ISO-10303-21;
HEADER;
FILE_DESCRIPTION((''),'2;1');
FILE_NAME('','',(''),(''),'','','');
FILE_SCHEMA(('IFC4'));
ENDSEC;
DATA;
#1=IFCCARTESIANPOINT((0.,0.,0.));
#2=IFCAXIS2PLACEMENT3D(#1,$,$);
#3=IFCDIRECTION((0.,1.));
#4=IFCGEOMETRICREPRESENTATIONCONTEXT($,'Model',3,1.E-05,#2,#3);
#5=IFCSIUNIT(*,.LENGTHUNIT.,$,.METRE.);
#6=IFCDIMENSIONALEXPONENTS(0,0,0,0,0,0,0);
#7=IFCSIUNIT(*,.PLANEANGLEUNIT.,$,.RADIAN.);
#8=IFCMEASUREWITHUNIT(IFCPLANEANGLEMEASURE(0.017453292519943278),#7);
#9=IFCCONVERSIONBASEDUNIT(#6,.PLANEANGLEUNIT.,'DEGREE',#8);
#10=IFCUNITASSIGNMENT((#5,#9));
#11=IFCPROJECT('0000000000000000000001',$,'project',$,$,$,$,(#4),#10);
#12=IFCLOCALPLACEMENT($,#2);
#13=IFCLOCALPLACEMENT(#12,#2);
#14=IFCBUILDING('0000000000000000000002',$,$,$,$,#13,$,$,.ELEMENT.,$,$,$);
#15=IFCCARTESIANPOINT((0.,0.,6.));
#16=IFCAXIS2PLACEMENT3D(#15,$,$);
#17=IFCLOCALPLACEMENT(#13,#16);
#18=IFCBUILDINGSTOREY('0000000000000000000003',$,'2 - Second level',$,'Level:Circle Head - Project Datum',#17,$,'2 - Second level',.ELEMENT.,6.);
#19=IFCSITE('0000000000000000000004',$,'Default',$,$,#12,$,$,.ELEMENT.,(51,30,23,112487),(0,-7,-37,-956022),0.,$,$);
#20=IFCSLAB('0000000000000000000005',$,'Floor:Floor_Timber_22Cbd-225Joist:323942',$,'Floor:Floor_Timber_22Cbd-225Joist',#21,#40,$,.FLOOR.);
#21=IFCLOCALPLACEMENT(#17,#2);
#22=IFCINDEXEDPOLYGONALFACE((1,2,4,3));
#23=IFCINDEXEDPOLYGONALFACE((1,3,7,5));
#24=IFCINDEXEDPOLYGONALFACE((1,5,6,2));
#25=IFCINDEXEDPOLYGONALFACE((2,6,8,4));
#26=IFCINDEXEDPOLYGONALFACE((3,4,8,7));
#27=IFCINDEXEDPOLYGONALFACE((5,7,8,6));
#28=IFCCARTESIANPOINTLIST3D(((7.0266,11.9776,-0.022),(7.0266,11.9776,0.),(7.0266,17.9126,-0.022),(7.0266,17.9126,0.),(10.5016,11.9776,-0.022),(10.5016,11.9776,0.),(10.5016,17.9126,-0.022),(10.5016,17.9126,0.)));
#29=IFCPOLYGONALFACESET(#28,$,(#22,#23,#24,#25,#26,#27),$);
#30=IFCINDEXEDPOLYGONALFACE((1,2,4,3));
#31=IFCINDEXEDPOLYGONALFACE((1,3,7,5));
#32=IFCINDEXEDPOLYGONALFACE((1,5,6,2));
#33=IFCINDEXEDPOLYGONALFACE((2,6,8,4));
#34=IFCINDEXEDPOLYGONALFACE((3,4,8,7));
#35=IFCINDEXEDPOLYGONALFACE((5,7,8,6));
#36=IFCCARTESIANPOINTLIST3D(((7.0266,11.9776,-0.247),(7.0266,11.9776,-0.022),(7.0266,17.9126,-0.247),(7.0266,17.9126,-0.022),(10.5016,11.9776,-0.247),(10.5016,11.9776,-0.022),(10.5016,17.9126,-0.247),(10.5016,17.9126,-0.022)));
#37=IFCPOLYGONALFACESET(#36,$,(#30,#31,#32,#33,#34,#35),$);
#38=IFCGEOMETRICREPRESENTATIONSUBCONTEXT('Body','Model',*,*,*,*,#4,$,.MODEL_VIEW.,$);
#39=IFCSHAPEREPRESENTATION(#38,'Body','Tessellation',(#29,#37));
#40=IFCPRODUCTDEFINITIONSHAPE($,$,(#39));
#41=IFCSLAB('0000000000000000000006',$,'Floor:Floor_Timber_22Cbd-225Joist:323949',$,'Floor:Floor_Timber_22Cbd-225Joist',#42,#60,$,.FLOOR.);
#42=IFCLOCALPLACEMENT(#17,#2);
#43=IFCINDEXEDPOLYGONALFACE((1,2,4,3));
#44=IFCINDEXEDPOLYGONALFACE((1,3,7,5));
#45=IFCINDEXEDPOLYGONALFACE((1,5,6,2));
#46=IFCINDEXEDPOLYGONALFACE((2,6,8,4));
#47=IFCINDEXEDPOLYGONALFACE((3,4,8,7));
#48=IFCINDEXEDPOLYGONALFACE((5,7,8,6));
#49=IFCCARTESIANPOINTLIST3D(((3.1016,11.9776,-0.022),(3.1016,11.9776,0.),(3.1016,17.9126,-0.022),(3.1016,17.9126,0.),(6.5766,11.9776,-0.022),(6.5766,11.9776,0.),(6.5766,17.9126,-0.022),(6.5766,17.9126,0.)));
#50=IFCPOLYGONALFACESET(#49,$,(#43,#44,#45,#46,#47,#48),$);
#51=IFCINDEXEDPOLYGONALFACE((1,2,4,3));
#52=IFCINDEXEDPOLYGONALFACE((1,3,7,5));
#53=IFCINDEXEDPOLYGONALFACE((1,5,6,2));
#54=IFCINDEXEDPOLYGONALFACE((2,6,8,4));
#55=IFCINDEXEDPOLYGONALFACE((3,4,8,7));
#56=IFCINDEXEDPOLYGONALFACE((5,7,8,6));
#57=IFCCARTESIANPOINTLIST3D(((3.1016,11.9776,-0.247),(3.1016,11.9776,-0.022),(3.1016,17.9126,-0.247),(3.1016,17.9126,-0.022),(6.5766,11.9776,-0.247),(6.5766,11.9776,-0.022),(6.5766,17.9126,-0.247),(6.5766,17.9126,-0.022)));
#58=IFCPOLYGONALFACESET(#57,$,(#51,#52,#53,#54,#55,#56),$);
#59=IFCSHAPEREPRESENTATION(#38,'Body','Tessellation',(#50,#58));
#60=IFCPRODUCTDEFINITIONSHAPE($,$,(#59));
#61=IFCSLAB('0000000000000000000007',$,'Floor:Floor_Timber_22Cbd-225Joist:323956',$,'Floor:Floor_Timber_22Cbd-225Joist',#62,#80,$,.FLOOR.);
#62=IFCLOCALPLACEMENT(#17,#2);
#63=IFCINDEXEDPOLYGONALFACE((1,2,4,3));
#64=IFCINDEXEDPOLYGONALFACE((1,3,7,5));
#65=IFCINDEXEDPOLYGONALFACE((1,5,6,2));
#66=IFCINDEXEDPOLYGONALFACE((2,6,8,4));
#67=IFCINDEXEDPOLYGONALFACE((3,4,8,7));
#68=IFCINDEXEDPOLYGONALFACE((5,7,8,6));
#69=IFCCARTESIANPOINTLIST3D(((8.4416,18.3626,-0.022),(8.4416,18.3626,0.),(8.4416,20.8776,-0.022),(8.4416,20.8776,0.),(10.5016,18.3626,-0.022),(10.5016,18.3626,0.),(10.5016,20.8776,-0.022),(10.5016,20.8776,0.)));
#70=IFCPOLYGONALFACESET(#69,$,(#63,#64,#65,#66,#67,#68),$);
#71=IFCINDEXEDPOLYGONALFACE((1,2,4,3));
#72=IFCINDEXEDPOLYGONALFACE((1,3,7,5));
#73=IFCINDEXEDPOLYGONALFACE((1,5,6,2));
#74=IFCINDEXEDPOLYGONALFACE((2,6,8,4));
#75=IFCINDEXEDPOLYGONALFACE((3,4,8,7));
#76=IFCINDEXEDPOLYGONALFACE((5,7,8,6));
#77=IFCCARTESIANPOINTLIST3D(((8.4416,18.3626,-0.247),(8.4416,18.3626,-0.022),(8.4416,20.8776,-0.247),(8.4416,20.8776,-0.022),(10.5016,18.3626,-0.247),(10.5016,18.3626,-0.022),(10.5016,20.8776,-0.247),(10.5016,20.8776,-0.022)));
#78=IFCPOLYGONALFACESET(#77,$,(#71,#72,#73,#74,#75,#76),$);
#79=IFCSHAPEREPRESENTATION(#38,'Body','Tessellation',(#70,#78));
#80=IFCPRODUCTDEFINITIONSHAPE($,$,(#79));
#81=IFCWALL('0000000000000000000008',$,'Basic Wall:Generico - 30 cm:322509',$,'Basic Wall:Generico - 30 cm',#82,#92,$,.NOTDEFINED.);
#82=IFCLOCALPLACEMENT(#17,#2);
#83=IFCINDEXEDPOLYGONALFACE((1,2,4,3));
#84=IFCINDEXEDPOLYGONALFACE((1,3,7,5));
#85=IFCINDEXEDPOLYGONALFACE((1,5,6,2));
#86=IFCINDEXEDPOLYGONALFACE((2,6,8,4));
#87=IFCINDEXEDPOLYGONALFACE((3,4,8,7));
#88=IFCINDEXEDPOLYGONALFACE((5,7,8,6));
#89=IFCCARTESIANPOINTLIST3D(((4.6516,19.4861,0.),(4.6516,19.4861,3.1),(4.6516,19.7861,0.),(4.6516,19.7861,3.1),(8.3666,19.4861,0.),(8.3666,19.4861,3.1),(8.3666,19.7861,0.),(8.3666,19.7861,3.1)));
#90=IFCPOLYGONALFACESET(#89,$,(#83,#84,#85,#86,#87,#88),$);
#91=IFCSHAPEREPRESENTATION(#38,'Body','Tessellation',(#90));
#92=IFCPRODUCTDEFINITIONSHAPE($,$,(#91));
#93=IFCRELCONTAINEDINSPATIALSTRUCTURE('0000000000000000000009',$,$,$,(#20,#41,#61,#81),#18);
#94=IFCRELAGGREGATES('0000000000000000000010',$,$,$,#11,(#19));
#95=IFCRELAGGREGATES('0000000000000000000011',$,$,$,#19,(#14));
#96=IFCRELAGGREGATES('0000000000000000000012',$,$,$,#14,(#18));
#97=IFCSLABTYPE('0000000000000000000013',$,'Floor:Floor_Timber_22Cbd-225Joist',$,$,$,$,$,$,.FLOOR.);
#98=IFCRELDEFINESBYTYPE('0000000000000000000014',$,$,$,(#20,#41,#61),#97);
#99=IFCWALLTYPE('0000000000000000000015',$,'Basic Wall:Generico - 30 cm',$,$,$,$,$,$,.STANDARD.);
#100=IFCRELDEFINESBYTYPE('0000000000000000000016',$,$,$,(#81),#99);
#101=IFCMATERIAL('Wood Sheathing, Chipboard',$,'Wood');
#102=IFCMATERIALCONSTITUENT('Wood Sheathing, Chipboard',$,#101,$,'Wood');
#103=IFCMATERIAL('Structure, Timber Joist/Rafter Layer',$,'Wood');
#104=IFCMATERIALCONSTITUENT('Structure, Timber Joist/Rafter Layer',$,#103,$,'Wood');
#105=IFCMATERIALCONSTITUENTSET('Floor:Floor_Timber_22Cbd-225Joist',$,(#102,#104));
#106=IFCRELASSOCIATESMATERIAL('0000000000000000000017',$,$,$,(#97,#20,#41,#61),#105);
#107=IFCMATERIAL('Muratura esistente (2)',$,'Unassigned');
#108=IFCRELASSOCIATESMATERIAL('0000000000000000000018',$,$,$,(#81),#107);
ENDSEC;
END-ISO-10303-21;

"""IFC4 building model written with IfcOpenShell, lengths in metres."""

from ifc_helpers import new_model, entity, si_unit, converted_unit, direction, frame, origin, place, context, subcontext, project, spatial, indexed_curve, outline, extrude, material, constituent, constituent_set, type_object, element, save


model = new_model("IFC4")

# Units and contexts
model_context = context("Model", 3, precision=1e-05, world=origin(), true_north=direction((0.0, 1.0)))
body_context = subcontext(model_context, "Body", "Model", "MODEL_VIEW")
ifc_project = project(units=[si_unit("LENGTHUNIT", "METRE"), converted_unit("PLANEANGLEUNIT", "DEGREE", entity("IfcPlaneAngleMeasure", 0.017453292519943278), si_unit("PLANEANGLEUNIT", "RADIAN"), dimensions=[0, 0, 0, 0, 0, 0, 0])], contexts=[model_context])

# Site, building, storey
site_placement = place(None, origin())
site = spatial("IfcSite", under=ifc_project, at=site_placement, Name="Default", CompositionType="ELEMENT", RefLatitude=(51, 30, 23, 112487), RefLongitude=(0, -7, -37, -956022), RefElevation=0.0)
building_placement = place(site_placement, origin())
building = spatial("IfcBuilding", under=site, at=building_placement, CompositionType="ELEMENT")
storey_placement = place(building_placement, frame((0.0, 0.0, 6.0)))
storey = spatial("IfcBuildingStorey", under=building, at=storey_placement, Name="2 - Second level", ObjectType="Level:Circle Head - Project Datum", LongName="2 - Second level", CompositionType="ELEMENT", Elevation=6.0)

# Slabs
ifc_material_1 = material(Name="Wood Sheathing, Chipboard", Category="Wood")
ifc_constituent_1 = constituent(ifc_material_1, Name="Wood Sheathing, Chipboard", Category="Wood")
ifc_material_2 = material(Name="Structure, Timber Joist/Rafter Layer", Category="Wood")
ifc_constituent_2 = constituent(ifc_material_2, Name="Structure, Timber Joist/Rafter Layer", Category="Wood")
ifc_constituent_set = constituent_set(constituents=[ifc_constituent_1, ifc_constituent_2], Name="Floor:Floor_Timber_22Cbd-225Joist")
slab_type = type_object("IfcSlabType", Name="Floor:Floor_Timber_22Cbd-225Joist", PredefinedType="FLOOR", material=ifc_constituent_set)
slab_1_placement = place(storey_placement, origin())
element("IfcSlab", 1, at=slab_1_placement, inside=storey, type_object=slab_type, material=ifc_constituent_set, Name="Floor:Floor_Timber_22Cbd-225Joist:323942", ObjectType="Floor:Floor_Timber_22Cbd-225Joist", PredefinedType="FLOOR", context=body_context, shape_type="SweptSolid", body=[
    extrude(outline(indexed_curve([(-2.9675, -1.7375), (2.9675, -1.7375), (2.9675, 1.7375), (-2.9675, 1.7375), (-2.9675, -1.7375)], self_intersect=False)), frame((8.7641, 14.9451, -0.022), z_axis=(0.0, 0.0, 1.0), x_axis=(0.0, -1.0, 0.0)), (0.0, 0.0, 1.0), 0.022),
    extrude(outline(indexed_curve([(-2.9675, -1.7375), (2.9675, -1.7375), (2.9675, 1.7375), (-2.9675, 1.7375), (-2.9675, -1.7375)], self_intersect=False)), frame((8.7641, 14.9451, -0.247), z_axis=(0.0, 0.0, 1.0), x_axis=(0.0, -1.0, 0.0)), (0.0, 0.0, 1.0), 0.225),
])
slab_2_placement = place(storey_placement, origin())
element("IfcSlab", 2, at=slab_2_placement, inside=storey, type_object=slab_type, material=ifc_constituent_set, Name="Floor:Floor_Timber_22Cbd-225Joist:323949", ObjectType="Floor:Floor_Timber_22Cbd-225Joist", PredefinedType="FLOOR", context=body_context, shape_type="SweptSolid", body=[
    extrude(outline(indexed_curve([(-1.7375, -2.9675), (1.7375, -2.9675), (1.7375, 2.9675), (-1.7375, 2.9675), (-1.7375, -2.9675)], self_intersect=False)), frame((4.8391, 14.9451, -0.022)), (0.0, 0.0, 1.0), 0.022),
    extrude(outline(indexed_curve([(-1.7375, -2.9675), (1.7375, -2.9675), (1.7375, 2.9675), (-1.7375, 2.9675), (-1.7375, -2.9675)], self_intersect=False)), frame((4.8391, 14.9451, -0.247)), (0.0, 0.0, 1.0), 0.225),
])
slab_3_placement = place(storey_placement, origin())
element("IfcSlab", 3, at=slab_3_placement, inside=storey, type_object=slab_type, material=ifc_constituent_set, Name="Floor:Floor_Timber_22Cbd-225Joist:323956", ObjectType="Floor:Floor_Timber_22Cbd-225Joist", PredefinedType="FLOOR", context=body_context, shape_type="SweptSolid", body=[
    extrude(outline(indexed_curve([(-1.2575, -1.03), (1.2575, -1.03), (1.2575, 1.03), (-1.2575, 1.03), (-1.2575, -1.03)], self_intersect=False)), frame((9.4716, 19.6201, -0.022), z_axis=(0.0, 0.0, 1.0), x_axis=(0.0, -1.0, 0.0)), (0.0, 0.0, 1.0), 0.022),
    extrude(outline(indexed_curve([(-1.2575, -1.03), (1.2575, -1.03), (1.2575, 1.03), (-1.2575, 1.03), (-1.2575, -1.03)], self_intersect=False)), frame((9.4716, 19.6201, -0.247), z_axis=(0.0, 0.0, 1.0), x_axis=(0.0, -1.0, 0.0)), (0.0, 0.0, 1.0), 0.225),
])

# Wall
ifc_material_3 = material(Name="Muratura esistente (2)", Category="Unassigned")
wall_type = type_object("IfcWallType", Name="Basic Wall:Generico - 30 cm", PredefinedType="STANDARD")
wall_placement = place(storey_placement, frame((4.6516, 19.6361, 0.0)))
element("IfcWall", 4, at=wall_placement, inside=storey, type_object=wall_type, material=ifc_material_3, Name="Basic Wall:Generico - 30 cm:322509", ObjectType="Basic Wall:Generico - 30 cm", PredefinedType="NOTDEFINED", context=body_context, shape_type="SweptSolid", body=[
    extrude(outline(indexed_curve([(3.715, 0.15), (0.0, 0.15), (0.0, -0.15), (3.715, -0.15), (3.715, 0.15)], self_intersect=False)), origin(), (0.0, 0.0, 1.0), 3.1),
])

save(model, "model.ifc")
